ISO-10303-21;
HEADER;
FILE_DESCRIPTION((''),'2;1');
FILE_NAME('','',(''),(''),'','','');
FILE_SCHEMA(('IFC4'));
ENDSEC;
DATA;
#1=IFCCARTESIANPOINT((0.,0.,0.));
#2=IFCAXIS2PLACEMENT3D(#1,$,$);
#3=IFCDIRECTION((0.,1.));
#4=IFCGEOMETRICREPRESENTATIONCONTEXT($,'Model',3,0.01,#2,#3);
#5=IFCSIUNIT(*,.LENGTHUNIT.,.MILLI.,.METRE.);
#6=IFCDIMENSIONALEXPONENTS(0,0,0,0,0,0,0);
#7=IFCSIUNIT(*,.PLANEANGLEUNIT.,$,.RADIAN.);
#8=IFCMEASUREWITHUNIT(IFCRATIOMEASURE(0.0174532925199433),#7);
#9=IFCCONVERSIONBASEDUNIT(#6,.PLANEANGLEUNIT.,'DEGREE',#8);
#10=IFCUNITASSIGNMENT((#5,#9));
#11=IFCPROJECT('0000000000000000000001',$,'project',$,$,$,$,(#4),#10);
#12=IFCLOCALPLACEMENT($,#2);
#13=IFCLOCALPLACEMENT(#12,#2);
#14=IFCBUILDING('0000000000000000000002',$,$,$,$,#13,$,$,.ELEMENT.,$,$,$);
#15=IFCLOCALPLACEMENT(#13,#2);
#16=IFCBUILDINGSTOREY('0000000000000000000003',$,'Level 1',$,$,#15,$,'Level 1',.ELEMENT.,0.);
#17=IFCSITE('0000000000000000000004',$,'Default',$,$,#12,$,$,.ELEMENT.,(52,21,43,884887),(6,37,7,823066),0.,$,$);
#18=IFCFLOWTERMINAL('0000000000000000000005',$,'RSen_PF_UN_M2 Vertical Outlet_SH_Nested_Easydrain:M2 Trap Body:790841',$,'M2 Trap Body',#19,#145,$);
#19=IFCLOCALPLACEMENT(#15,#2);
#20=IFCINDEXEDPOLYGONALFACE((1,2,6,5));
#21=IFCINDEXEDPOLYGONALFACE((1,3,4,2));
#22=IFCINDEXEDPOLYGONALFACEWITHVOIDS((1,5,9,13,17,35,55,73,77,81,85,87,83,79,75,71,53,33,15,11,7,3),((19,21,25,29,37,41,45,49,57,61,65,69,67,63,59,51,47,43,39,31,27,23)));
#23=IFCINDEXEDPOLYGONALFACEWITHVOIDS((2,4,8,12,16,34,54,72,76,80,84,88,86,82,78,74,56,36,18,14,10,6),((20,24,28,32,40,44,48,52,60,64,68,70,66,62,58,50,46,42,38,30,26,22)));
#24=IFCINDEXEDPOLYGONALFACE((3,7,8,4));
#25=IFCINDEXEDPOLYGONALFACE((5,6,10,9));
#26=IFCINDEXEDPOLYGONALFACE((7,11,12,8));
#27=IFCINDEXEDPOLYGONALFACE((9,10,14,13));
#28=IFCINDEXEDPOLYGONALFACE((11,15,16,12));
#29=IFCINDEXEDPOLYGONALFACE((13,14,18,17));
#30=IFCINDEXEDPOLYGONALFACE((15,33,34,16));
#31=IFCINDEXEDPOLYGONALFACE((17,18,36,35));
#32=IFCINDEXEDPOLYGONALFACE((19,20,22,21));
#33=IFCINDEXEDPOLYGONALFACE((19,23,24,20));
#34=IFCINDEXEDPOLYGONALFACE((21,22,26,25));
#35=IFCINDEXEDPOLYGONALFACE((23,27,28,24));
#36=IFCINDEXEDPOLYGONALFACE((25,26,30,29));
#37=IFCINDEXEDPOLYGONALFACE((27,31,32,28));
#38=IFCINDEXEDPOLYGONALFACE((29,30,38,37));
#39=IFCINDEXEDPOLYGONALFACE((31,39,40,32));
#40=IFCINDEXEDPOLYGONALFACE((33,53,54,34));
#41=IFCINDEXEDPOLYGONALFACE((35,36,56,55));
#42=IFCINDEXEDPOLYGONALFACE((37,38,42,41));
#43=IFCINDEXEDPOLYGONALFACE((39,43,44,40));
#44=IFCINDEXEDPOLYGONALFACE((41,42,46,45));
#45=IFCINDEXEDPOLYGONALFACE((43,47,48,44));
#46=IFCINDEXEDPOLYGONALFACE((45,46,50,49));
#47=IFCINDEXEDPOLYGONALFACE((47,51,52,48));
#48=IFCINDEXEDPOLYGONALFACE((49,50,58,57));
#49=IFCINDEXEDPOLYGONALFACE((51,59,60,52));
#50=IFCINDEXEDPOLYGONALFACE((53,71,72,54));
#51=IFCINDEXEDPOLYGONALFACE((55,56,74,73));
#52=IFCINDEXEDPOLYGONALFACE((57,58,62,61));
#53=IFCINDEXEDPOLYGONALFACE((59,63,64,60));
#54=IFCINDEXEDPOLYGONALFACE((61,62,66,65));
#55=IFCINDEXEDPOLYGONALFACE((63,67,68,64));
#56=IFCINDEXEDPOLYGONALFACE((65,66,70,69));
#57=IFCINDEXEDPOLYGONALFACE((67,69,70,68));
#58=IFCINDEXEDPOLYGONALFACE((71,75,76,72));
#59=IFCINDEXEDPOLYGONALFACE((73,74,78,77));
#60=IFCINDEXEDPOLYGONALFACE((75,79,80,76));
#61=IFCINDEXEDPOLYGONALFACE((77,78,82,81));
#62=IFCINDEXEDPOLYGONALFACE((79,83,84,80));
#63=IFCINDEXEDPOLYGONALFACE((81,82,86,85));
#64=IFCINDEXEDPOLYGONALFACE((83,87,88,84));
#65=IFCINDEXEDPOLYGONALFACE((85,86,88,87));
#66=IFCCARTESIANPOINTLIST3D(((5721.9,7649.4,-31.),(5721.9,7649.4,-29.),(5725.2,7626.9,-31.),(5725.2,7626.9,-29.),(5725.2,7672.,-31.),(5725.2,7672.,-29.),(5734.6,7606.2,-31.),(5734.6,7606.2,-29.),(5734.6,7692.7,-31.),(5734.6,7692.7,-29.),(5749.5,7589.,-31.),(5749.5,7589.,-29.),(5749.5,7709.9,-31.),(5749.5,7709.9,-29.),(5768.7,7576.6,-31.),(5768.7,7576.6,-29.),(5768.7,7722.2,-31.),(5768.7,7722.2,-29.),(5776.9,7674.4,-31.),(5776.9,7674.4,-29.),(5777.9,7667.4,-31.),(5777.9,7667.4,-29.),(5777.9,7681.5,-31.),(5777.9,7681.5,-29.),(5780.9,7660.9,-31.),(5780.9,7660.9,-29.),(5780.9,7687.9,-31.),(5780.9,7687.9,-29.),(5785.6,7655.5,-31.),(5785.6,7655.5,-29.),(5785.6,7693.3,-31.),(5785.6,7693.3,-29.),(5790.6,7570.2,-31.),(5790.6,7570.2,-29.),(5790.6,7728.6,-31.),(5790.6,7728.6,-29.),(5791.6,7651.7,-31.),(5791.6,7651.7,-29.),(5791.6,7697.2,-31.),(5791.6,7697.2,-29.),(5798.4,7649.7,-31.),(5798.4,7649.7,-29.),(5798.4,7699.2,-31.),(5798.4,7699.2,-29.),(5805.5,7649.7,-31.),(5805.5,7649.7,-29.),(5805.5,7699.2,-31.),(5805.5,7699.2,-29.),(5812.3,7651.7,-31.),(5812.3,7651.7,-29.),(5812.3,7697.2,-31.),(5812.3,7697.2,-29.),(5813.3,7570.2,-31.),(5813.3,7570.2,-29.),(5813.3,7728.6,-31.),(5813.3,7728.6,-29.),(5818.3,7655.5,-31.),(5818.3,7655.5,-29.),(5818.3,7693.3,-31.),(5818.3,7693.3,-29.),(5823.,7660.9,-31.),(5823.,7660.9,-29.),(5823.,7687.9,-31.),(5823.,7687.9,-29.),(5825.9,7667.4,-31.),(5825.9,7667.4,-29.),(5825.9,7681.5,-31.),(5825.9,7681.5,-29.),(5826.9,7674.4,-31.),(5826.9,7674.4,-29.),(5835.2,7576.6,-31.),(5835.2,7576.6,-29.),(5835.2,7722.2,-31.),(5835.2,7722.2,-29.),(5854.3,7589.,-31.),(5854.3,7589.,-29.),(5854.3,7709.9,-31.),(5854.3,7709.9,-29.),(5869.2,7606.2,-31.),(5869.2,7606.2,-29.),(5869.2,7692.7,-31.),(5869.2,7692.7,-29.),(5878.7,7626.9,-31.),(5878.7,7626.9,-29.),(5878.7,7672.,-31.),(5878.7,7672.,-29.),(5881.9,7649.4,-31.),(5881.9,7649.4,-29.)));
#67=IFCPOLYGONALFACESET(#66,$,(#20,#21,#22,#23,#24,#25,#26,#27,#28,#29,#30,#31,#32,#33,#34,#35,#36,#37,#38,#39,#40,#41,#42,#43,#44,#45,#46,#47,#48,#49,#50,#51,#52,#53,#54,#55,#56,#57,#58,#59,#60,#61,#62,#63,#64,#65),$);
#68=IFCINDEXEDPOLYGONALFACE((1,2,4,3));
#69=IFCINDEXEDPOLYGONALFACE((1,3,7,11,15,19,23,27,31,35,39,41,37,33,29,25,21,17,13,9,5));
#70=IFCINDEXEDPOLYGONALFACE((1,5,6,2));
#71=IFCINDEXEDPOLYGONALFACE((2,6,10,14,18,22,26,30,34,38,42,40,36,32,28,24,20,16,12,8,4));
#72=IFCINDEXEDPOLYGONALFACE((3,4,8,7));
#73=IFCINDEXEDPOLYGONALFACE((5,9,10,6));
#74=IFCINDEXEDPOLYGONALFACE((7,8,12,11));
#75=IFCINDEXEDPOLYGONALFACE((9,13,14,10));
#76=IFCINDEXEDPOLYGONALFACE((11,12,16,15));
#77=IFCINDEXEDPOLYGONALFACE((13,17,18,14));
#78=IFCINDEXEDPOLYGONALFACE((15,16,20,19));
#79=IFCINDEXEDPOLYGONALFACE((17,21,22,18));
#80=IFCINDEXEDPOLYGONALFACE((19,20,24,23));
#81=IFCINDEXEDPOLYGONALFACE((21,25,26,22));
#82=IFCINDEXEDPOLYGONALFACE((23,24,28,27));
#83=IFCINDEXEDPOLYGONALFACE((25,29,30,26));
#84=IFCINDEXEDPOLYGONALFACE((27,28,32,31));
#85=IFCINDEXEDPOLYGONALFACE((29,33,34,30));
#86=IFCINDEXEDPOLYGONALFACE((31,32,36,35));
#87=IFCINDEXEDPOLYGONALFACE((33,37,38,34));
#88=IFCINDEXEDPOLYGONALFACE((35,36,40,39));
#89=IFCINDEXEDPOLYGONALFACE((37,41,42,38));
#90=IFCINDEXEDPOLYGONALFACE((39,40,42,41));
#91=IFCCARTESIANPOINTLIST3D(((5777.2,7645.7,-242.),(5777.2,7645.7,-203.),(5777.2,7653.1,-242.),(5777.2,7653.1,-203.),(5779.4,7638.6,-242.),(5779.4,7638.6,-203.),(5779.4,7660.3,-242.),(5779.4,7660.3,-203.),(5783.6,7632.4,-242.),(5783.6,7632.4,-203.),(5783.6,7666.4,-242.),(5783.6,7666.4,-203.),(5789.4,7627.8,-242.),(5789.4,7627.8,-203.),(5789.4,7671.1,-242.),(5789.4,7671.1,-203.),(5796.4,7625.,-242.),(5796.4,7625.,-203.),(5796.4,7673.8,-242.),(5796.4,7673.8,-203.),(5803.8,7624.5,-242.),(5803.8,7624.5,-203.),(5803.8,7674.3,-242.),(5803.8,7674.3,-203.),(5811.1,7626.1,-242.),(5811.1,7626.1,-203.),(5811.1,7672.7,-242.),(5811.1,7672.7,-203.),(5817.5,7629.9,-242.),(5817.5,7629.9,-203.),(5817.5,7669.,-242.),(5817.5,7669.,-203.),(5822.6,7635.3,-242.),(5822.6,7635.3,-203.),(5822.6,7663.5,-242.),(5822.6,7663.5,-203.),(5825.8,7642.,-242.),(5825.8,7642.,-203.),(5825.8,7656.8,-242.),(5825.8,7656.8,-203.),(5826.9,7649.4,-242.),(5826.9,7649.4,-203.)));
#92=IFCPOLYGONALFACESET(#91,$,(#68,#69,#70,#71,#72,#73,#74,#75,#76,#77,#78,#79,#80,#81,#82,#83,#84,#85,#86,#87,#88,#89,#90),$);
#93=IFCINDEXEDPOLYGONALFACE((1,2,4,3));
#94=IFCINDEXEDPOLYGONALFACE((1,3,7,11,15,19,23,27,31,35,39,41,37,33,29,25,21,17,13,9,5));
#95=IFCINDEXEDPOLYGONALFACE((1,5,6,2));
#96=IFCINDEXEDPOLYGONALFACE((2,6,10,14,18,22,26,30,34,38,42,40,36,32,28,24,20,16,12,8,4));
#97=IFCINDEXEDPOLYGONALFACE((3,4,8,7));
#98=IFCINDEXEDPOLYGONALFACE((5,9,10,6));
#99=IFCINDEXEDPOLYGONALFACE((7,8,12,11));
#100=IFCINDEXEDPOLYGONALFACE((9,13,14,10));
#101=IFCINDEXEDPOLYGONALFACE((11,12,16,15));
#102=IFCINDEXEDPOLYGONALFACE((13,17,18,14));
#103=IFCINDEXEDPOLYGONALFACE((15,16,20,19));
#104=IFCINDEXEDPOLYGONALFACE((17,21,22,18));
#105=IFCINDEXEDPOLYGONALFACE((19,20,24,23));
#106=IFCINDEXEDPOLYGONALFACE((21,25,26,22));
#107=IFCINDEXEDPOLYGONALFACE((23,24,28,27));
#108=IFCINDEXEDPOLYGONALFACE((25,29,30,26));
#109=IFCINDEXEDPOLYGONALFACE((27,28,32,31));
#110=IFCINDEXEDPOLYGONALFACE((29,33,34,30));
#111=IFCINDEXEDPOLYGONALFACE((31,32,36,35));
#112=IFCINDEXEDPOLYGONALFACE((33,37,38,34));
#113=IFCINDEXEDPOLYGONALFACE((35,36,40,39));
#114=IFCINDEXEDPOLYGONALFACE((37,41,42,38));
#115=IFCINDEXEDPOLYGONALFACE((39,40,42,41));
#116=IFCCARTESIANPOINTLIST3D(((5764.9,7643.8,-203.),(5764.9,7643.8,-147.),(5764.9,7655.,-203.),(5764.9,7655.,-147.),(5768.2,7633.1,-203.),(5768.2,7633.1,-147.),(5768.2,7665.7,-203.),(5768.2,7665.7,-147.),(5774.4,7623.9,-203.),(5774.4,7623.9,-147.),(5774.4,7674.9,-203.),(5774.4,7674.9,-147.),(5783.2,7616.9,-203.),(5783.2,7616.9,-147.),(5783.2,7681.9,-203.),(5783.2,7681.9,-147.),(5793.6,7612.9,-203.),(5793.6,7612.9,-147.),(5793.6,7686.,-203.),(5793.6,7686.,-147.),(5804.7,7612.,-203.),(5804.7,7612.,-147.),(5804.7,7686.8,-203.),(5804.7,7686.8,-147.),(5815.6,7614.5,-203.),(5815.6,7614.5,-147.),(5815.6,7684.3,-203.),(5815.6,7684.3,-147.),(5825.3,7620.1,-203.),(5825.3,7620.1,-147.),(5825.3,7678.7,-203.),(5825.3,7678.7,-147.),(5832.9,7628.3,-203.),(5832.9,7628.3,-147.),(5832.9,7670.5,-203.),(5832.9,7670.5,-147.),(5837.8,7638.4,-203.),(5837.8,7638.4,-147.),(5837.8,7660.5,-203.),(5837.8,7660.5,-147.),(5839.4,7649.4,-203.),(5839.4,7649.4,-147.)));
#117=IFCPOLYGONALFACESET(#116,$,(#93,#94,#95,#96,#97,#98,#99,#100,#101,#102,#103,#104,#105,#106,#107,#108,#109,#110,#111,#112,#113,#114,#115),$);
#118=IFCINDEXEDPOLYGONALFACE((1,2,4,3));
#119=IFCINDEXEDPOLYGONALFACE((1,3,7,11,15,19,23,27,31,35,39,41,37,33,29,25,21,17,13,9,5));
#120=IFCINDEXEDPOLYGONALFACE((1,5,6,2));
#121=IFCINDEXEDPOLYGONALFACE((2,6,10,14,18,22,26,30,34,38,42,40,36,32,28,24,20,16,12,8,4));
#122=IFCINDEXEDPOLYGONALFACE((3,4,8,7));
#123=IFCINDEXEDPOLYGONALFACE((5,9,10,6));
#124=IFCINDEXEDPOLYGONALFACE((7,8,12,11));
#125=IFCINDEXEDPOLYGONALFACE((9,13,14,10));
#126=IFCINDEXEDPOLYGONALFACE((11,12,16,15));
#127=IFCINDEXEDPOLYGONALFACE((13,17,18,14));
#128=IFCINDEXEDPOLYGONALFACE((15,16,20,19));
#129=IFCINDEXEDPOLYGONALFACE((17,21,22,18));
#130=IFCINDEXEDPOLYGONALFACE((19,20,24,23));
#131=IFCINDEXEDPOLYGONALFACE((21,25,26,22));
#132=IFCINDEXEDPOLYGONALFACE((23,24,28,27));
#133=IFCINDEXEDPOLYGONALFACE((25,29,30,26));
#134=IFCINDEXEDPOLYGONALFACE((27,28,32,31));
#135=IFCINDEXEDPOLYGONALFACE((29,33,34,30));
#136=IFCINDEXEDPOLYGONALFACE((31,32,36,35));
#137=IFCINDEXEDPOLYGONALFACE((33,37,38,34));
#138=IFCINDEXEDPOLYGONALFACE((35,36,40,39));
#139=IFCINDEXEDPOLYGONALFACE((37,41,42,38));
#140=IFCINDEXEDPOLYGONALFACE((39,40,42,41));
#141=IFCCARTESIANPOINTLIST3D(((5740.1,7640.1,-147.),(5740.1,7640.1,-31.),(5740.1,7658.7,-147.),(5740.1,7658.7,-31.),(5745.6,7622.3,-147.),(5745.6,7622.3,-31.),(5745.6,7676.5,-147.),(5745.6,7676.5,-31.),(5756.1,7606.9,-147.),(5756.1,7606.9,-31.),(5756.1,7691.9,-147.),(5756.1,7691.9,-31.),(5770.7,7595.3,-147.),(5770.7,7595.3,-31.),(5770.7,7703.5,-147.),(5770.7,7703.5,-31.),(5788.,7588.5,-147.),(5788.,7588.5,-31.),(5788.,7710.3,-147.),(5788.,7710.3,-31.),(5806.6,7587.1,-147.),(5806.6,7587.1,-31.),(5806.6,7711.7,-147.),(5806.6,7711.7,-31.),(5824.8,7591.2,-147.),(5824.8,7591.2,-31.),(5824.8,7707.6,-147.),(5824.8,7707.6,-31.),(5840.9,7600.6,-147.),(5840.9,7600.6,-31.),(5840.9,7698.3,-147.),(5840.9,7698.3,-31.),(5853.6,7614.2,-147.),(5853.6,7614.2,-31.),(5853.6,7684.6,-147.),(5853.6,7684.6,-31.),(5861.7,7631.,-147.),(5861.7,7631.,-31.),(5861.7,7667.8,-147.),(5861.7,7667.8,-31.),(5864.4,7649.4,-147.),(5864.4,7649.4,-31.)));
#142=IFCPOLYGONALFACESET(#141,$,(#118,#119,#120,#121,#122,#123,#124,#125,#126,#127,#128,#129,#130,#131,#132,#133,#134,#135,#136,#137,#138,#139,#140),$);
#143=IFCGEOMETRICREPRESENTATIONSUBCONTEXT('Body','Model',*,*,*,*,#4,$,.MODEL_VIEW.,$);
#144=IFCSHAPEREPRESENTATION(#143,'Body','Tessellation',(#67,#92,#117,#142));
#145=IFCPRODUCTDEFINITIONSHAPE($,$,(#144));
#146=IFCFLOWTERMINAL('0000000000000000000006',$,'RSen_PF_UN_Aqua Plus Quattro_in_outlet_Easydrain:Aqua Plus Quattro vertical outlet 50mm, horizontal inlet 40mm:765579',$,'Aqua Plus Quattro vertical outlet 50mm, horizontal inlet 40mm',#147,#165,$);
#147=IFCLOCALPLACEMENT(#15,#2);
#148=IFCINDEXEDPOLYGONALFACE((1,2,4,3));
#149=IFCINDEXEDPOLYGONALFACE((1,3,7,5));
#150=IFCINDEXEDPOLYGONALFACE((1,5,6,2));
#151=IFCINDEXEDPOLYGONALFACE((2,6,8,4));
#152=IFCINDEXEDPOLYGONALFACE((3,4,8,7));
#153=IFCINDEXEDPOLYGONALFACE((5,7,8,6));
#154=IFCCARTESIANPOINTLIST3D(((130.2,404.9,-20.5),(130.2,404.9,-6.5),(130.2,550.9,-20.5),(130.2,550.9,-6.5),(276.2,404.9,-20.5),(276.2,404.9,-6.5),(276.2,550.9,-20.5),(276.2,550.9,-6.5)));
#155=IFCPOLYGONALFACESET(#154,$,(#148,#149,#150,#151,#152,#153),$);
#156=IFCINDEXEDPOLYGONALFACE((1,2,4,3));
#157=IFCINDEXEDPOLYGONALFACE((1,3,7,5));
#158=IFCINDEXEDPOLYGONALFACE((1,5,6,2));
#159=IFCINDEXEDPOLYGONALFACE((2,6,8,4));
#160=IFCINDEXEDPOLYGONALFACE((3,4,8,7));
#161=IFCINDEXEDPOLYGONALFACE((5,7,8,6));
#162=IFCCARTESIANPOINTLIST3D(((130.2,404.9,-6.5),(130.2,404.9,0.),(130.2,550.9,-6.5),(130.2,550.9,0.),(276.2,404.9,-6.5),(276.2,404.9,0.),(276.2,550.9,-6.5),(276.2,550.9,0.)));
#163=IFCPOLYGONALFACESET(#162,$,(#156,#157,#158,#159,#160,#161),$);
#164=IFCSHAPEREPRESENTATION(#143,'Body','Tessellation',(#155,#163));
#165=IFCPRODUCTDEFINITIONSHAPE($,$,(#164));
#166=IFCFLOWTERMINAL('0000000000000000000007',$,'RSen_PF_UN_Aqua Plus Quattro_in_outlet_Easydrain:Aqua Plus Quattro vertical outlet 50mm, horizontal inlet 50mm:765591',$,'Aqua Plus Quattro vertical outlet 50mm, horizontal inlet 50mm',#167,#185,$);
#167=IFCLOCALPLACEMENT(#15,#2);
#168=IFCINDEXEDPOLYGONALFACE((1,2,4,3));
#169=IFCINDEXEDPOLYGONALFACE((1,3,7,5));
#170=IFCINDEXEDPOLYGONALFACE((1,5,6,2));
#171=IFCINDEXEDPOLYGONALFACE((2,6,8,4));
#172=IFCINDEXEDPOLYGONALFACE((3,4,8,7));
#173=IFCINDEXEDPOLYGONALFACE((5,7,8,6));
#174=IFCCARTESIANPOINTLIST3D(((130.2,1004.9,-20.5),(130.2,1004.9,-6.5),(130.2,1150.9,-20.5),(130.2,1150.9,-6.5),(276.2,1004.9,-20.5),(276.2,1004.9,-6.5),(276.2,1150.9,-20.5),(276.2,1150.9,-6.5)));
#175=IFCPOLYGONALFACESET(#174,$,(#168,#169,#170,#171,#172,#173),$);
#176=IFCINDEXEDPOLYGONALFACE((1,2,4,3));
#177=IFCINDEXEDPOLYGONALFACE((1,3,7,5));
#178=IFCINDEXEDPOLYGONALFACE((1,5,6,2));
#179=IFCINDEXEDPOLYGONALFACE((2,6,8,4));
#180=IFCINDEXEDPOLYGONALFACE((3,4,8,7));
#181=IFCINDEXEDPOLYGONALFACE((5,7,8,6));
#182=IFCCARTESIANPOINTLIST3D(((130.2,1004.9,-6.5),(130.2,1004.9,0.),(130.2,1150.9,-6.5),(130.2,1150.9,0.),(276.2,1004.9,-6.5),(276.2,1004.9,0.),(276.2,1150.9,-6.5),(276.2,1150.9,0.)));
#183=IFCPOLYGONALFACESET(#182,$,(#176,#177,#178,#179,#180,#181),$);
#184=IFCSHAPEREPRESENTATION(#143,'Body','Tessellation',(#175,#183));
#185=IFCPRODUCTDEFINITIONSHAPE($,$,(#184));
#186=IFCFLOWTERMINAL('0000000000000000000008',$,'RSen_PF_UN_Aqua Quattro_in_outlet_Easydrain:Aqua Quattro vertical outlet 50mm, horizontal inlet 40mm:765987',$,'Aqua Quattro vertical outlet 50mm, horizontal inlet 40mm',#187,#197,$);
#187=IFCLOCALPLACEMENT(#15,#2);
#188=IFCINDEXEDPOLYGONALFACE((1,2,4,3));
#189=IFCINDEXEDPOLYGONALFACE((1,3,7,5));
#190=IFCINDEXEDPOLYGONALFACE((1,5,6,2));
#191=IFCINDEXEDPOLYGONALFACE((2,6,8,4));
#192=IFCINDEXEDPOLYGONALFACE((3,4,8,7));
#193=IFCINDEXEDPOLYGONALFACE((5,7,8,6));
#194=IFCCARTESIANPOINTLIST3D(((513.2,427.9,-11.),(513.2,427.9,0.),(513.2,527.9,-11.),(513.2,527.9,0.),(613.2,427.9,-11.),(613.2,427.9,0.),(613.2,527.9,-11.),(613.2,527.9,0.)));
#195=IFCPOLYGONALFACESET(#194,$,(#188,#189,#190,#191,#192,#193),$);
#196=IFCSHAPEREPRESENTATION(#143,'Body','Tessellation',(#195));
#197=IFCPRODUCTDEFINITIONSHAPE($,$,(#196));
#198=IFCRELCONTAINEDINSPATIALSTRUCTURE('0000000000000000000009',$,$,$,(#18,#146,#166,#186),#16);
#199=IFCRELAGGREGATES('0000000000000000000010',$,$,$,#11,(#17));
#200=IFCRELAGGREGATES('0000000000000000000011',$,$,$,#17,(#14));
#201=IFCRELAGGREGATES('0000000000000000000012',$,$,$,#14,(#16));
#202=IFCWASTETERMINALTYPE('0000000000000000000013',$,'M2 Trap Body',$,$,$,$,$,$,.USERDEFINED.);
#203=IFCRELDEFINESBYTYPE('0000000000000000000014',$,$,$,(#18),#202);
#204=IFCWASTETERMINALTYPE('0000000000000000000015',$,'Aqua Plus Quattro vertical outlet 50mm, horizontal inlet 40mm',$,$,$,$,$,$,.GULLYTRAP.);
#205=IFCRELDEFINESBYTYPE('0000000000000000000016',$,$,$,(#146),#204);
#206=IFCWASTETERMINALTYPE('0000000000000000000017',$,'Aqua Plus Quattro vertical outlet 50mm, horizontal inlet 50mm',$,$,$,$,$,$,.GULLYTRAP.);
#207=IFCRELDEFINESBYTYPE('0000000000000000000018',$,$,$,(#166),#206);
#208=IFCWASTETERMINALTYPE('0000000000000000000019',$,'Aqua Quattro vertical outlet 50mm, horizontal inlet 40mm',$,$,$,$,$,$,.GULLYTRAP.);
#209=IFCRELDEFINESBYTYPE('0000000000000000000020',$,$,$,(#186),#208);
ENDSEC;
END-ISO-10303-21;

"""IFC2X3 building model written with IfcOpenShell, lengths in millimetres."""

from ifc_helpers import new_model, entity, si_unit, converted_unit, direction, frame, frame_2d, origin, origin_2d_with_axis, place, context, subcontext, project, spatial, circle_curve, parameter, trimmed, segment, composite_curve, rectangle, circle, outline, extrude, source, transform, mapped, type_object, type_shapes, element, save


model = new_model("IFC2X3")

# Units and contexts
model_context = context("Model", 3, precision=0.01, world=origin(), true_north=direction((0.0, 1.0)))
body_context = subcontext(model_context, "Body", "Model", "MODEL_VIEW")
ifc_project = project(units=[si_unit("LENGTHUNIT", "METRE", prefix="MILLI"), converted_unit("PLANEANGLEUNIT", "DEGREE", entity("IfcRatioMeasure", 0.0174532925199433), si_unit("PLANEANGLEUNIT", "RADIAN"), dimensions=[0, 0, 0, 0, 0, 0, 0])], contexts=[model_context])

# Site, building, storey
site_placement = place(None, origin())
site = spatial("IfcSite", under=ifc_project, at=site_placement, Name="Default", CompositionType="ELEMENT", RefLatitude=(52, 21, 43, 884887), RefLongitude=(6, 37, 7, 823066), RefElevation=0.0)
building_placement = place(site_placement, origin())
building = spatial("IfcBuilding", under=site, at=building_placement, CompositionType="ELEMENT")
storey_placement = place(building_placement, origin())
storey = spatial("IfcBuildingStorey", under=building, at=storey_placement, Name="Level 1", LongName="Level 1", CompositionType="ELEMENT", Elevation=0.0)

# Flow terminals
waste_terminal_type_1 = type_object("IfcWasteTerminalType", Name="M2 Trap Body", PredefinedType="USERDEFINED")
shared_shape_1 = source(origin(), body_context, "Body", "SweptSolid", [
    extrude(outline(composite_curve([segment(trimmed(circle_curve(origin_2d_with_axis(), 80.0), [parameter(0.0)], [parameter(180.0)], True, "PARAMETER"), True, "CONTINUOUS"), segment(trimmed(circle_curve(origin_2d_with_axis(), 80.0), [parameter(180.0)], [parameter(360.0)], True, "PARAMETER"), True, "CONTINUOUS")], self_intersect=False), holes=[composite_curve([segment(trimmed(circle_curve(frame_2d((0.0, 25.0), x_axis=(1.0, 0.0)), 25.0), [parameter(180.0)], [parameter(360.0)], True, "PARAMETER"), False, "CONTINUOUS"), segment(trimmed(circle_curve(frame_2d((0.0, 25.0), x_axis=(1.0, 0.0)), 25.0), [parameter(0.0)], [parameter(180.0)], True, "PARAMETER"), False, "CONTINUOUS")], self_intersect=False)]), frame((0.0, -25.0, -2.0)), (0.0, 0.0, 1.0), 2.0),
    extrude(circle(Radius=25.0, at=frame_2d((0.0, 0.0), x_axis=(1.0, 0.0))), frame((0.0, -25.0, -213.0)), (0.0, 0.0, 1.0), 39.0),
    extrude(circle(Radius=37.5, at=frame_2d((0.0, 0.0), x_axis=(1.0, 0.0))), frame((0.0, -25.0, -174.0)), (0.0, 0.0, 1.0), 56.0),
    extrude(circle(Radius=62.5, at=frame_2d((0.0, 0.0), x_axis=(1.0, 0.0))), frame((0.0, -25.0, -118.0)), (0.0, 0.0, 1.0), 116.0),
])
type_shapes(waste_terminal_type_1, [shared_shape_1])
for number, where, name in (
    (1, (5801.9, 7674.4, -29.0), "RSen_PF_UN_M2 Vertical Outlet_SH_Nested_Easydrain:M2 Trap Body:790841"),
):
    element("IfcFlowTerminal", number, at=place(storey_placement, frame(where)), inside=storey, type_object=waste_terminal_type_1, Name=name, ObjectType="M2 Trap Body", context=body_context, shape_type="MappedRepresentation", body=[
        mapped(shared_shape_1, transform((0.0, 0.0, 0.0), scale=1.0)),
    ])
waste_terminal_type_2 = type_object("IfcWasteTerminalType", Name="Aqua Plus Quattro vertical outlet 50mm, horizontal inlet 40mm", PredefinedType="GULLYTRAP")
shared_shape_2 = source(origin(), body_context, "Body", "SweptSolid", [
    extrude(rectangle(XDim=146.0, YDim=146.0, at=origin_2d_with_axis()), frame((0.0, 0.0, -20.5), z_axis=(0.0, 0.0, 1.0), x_axis=(-1.0, 0.0, 0.0)), (0.0, 0.0, 1.0), 14.0),
    extrude(rectangle(XDim=146.0, YDim=146.0, at=origin_2d_with_axis()), frame((0.0, 0.0, -6.5), z_axis=(0.0, 0.0, 1.0), x_axis=(-1.0, 0.0, 0.0)), (0.0, 0.0, 1.0), 6.5),
])
type_shapes(waste_terminal_type_2, [shared_shape_2])
flow_terminal_1_placement = place(storey_placement, frame((203.2, 477.9, 0.0)))
element("IfcFlowTerminal", 2, at=flow_terminal_1_placement, inside=storey, type_object=waste_terminal_type_2, Name="RSen_PF_UN_Aqua Plus Quattro_in_outlet_Easydrain:Aqua Plus Quattro vertical outlet 50mm, horizontal inlet 40mm:765579", ObjectType="Aqua Plus Quattro vertical outlet 50mm, horizontal inlet 40mm", context=body_context, shape_type="MappedRepresentation", body=[
    mapped(shared_shape_2, transform((0.0, 0.0, 0.0), scale=1.0)),
])
waste_terminal_type_3 = type_object("IfcWasteTerminalType", Name="Aqua Plus Quattro vertical outlet 50mm, horizontal inlet 50mm", PredefinedType="GULLYTRAP")
shared_shape_3 = source(origin(), body_context, "Body", "SweptSolid", [
    extrude(rectangle(XDim=146.0, YDim=146.0, at=origin_2d_with_axis()), frame((0.0, 0.0, -20.5), z_axis=(0.0, 0.0, 1.0), x_axis=(-1.0, 0.0, 0.0)), (0.0, 0.0, 1.0), 14.0),
    extrude(rectangle(XDim=146.0, YDim=146.0, at=origin_2d_with_axis()), frame((0.0, 0.0, -6.5), z_axis=(0.0, 0.0, 1.0), x_axis=(-1.0, 0.0, 0.0)), (0.0, 0.0, 1.0), 6.5),
])
type_shapes(waste_terminal_type_3, [shared_shape_3])
flow_terminal_2_placement = place(storey_placement, frame((203.2, 1077.9, 0.0)))
element("IfcFlowTerminal", 3, at=flow_terminal_2_placement, inside=storey, type_object=waste_terminal_type_3, Name="RSen_PF_UN_Aqua Plus Quattro_in_outlet_Easydrain:Aqua Plus Quattro vertical outlet 50mm, horizontal inlet 50mm:765591", ObjectType="Aqua Plus Quattro vertical outlet 50mm, horizontal inlet 50mm", context=body_context, shape_type="MappedRepresentation", body=[
    mapped(shared_shape_3, transform((0.0, 0.0, 0.0), scale=1.0)),
])
waste_terminal_type_4 = type_object("IfcWasteTerminalType", Name="Aqua Quattro vertical outlet 50mm, horizontal inlet 40mm", PredefinedType="GULLYTRAP")
shared_shape_4 = source(origin(), body_context, "Body", "SweptSolid", [
    extrude(rectangle(XDim=100.0, YDim=100.0, at=origin_2d_with_axis()), frame((0.0, 0.0, -11.0), z_axis=(0.0, 0.0, 1.0), x_axis=(-1.0, 0.0, 0.0)), (0.0, 0.0, 1.0), 11.0),
])
type_shapes(waste_terminal_type_4, [shared_shape_4])
flow_terminal_3_placement = place(storey_placement, frame((563.2, 477.9, 0.0)))
element("IfcFlowTerminal", 4, at=flow_terminal_3_placement, inside=storey, type_object=waste_terminal_type_4, Name="RSen_PF_UN_Aqua Quattro_in_outlet_Easydrain:Aqua Quattro vertical outlet 50mm, horizontal inlet 40mm:765987", ObjectType="Aqua Quattro vertical outlet 50mm, horizontal inlet 40mm", context=body_context, shape_type="MappedRepresentation", body=[
    mapped(shared_shape_4, transform((0.0, 0.0, 0.0), scale=1.0)),
])

save(model, "model.ifc")
